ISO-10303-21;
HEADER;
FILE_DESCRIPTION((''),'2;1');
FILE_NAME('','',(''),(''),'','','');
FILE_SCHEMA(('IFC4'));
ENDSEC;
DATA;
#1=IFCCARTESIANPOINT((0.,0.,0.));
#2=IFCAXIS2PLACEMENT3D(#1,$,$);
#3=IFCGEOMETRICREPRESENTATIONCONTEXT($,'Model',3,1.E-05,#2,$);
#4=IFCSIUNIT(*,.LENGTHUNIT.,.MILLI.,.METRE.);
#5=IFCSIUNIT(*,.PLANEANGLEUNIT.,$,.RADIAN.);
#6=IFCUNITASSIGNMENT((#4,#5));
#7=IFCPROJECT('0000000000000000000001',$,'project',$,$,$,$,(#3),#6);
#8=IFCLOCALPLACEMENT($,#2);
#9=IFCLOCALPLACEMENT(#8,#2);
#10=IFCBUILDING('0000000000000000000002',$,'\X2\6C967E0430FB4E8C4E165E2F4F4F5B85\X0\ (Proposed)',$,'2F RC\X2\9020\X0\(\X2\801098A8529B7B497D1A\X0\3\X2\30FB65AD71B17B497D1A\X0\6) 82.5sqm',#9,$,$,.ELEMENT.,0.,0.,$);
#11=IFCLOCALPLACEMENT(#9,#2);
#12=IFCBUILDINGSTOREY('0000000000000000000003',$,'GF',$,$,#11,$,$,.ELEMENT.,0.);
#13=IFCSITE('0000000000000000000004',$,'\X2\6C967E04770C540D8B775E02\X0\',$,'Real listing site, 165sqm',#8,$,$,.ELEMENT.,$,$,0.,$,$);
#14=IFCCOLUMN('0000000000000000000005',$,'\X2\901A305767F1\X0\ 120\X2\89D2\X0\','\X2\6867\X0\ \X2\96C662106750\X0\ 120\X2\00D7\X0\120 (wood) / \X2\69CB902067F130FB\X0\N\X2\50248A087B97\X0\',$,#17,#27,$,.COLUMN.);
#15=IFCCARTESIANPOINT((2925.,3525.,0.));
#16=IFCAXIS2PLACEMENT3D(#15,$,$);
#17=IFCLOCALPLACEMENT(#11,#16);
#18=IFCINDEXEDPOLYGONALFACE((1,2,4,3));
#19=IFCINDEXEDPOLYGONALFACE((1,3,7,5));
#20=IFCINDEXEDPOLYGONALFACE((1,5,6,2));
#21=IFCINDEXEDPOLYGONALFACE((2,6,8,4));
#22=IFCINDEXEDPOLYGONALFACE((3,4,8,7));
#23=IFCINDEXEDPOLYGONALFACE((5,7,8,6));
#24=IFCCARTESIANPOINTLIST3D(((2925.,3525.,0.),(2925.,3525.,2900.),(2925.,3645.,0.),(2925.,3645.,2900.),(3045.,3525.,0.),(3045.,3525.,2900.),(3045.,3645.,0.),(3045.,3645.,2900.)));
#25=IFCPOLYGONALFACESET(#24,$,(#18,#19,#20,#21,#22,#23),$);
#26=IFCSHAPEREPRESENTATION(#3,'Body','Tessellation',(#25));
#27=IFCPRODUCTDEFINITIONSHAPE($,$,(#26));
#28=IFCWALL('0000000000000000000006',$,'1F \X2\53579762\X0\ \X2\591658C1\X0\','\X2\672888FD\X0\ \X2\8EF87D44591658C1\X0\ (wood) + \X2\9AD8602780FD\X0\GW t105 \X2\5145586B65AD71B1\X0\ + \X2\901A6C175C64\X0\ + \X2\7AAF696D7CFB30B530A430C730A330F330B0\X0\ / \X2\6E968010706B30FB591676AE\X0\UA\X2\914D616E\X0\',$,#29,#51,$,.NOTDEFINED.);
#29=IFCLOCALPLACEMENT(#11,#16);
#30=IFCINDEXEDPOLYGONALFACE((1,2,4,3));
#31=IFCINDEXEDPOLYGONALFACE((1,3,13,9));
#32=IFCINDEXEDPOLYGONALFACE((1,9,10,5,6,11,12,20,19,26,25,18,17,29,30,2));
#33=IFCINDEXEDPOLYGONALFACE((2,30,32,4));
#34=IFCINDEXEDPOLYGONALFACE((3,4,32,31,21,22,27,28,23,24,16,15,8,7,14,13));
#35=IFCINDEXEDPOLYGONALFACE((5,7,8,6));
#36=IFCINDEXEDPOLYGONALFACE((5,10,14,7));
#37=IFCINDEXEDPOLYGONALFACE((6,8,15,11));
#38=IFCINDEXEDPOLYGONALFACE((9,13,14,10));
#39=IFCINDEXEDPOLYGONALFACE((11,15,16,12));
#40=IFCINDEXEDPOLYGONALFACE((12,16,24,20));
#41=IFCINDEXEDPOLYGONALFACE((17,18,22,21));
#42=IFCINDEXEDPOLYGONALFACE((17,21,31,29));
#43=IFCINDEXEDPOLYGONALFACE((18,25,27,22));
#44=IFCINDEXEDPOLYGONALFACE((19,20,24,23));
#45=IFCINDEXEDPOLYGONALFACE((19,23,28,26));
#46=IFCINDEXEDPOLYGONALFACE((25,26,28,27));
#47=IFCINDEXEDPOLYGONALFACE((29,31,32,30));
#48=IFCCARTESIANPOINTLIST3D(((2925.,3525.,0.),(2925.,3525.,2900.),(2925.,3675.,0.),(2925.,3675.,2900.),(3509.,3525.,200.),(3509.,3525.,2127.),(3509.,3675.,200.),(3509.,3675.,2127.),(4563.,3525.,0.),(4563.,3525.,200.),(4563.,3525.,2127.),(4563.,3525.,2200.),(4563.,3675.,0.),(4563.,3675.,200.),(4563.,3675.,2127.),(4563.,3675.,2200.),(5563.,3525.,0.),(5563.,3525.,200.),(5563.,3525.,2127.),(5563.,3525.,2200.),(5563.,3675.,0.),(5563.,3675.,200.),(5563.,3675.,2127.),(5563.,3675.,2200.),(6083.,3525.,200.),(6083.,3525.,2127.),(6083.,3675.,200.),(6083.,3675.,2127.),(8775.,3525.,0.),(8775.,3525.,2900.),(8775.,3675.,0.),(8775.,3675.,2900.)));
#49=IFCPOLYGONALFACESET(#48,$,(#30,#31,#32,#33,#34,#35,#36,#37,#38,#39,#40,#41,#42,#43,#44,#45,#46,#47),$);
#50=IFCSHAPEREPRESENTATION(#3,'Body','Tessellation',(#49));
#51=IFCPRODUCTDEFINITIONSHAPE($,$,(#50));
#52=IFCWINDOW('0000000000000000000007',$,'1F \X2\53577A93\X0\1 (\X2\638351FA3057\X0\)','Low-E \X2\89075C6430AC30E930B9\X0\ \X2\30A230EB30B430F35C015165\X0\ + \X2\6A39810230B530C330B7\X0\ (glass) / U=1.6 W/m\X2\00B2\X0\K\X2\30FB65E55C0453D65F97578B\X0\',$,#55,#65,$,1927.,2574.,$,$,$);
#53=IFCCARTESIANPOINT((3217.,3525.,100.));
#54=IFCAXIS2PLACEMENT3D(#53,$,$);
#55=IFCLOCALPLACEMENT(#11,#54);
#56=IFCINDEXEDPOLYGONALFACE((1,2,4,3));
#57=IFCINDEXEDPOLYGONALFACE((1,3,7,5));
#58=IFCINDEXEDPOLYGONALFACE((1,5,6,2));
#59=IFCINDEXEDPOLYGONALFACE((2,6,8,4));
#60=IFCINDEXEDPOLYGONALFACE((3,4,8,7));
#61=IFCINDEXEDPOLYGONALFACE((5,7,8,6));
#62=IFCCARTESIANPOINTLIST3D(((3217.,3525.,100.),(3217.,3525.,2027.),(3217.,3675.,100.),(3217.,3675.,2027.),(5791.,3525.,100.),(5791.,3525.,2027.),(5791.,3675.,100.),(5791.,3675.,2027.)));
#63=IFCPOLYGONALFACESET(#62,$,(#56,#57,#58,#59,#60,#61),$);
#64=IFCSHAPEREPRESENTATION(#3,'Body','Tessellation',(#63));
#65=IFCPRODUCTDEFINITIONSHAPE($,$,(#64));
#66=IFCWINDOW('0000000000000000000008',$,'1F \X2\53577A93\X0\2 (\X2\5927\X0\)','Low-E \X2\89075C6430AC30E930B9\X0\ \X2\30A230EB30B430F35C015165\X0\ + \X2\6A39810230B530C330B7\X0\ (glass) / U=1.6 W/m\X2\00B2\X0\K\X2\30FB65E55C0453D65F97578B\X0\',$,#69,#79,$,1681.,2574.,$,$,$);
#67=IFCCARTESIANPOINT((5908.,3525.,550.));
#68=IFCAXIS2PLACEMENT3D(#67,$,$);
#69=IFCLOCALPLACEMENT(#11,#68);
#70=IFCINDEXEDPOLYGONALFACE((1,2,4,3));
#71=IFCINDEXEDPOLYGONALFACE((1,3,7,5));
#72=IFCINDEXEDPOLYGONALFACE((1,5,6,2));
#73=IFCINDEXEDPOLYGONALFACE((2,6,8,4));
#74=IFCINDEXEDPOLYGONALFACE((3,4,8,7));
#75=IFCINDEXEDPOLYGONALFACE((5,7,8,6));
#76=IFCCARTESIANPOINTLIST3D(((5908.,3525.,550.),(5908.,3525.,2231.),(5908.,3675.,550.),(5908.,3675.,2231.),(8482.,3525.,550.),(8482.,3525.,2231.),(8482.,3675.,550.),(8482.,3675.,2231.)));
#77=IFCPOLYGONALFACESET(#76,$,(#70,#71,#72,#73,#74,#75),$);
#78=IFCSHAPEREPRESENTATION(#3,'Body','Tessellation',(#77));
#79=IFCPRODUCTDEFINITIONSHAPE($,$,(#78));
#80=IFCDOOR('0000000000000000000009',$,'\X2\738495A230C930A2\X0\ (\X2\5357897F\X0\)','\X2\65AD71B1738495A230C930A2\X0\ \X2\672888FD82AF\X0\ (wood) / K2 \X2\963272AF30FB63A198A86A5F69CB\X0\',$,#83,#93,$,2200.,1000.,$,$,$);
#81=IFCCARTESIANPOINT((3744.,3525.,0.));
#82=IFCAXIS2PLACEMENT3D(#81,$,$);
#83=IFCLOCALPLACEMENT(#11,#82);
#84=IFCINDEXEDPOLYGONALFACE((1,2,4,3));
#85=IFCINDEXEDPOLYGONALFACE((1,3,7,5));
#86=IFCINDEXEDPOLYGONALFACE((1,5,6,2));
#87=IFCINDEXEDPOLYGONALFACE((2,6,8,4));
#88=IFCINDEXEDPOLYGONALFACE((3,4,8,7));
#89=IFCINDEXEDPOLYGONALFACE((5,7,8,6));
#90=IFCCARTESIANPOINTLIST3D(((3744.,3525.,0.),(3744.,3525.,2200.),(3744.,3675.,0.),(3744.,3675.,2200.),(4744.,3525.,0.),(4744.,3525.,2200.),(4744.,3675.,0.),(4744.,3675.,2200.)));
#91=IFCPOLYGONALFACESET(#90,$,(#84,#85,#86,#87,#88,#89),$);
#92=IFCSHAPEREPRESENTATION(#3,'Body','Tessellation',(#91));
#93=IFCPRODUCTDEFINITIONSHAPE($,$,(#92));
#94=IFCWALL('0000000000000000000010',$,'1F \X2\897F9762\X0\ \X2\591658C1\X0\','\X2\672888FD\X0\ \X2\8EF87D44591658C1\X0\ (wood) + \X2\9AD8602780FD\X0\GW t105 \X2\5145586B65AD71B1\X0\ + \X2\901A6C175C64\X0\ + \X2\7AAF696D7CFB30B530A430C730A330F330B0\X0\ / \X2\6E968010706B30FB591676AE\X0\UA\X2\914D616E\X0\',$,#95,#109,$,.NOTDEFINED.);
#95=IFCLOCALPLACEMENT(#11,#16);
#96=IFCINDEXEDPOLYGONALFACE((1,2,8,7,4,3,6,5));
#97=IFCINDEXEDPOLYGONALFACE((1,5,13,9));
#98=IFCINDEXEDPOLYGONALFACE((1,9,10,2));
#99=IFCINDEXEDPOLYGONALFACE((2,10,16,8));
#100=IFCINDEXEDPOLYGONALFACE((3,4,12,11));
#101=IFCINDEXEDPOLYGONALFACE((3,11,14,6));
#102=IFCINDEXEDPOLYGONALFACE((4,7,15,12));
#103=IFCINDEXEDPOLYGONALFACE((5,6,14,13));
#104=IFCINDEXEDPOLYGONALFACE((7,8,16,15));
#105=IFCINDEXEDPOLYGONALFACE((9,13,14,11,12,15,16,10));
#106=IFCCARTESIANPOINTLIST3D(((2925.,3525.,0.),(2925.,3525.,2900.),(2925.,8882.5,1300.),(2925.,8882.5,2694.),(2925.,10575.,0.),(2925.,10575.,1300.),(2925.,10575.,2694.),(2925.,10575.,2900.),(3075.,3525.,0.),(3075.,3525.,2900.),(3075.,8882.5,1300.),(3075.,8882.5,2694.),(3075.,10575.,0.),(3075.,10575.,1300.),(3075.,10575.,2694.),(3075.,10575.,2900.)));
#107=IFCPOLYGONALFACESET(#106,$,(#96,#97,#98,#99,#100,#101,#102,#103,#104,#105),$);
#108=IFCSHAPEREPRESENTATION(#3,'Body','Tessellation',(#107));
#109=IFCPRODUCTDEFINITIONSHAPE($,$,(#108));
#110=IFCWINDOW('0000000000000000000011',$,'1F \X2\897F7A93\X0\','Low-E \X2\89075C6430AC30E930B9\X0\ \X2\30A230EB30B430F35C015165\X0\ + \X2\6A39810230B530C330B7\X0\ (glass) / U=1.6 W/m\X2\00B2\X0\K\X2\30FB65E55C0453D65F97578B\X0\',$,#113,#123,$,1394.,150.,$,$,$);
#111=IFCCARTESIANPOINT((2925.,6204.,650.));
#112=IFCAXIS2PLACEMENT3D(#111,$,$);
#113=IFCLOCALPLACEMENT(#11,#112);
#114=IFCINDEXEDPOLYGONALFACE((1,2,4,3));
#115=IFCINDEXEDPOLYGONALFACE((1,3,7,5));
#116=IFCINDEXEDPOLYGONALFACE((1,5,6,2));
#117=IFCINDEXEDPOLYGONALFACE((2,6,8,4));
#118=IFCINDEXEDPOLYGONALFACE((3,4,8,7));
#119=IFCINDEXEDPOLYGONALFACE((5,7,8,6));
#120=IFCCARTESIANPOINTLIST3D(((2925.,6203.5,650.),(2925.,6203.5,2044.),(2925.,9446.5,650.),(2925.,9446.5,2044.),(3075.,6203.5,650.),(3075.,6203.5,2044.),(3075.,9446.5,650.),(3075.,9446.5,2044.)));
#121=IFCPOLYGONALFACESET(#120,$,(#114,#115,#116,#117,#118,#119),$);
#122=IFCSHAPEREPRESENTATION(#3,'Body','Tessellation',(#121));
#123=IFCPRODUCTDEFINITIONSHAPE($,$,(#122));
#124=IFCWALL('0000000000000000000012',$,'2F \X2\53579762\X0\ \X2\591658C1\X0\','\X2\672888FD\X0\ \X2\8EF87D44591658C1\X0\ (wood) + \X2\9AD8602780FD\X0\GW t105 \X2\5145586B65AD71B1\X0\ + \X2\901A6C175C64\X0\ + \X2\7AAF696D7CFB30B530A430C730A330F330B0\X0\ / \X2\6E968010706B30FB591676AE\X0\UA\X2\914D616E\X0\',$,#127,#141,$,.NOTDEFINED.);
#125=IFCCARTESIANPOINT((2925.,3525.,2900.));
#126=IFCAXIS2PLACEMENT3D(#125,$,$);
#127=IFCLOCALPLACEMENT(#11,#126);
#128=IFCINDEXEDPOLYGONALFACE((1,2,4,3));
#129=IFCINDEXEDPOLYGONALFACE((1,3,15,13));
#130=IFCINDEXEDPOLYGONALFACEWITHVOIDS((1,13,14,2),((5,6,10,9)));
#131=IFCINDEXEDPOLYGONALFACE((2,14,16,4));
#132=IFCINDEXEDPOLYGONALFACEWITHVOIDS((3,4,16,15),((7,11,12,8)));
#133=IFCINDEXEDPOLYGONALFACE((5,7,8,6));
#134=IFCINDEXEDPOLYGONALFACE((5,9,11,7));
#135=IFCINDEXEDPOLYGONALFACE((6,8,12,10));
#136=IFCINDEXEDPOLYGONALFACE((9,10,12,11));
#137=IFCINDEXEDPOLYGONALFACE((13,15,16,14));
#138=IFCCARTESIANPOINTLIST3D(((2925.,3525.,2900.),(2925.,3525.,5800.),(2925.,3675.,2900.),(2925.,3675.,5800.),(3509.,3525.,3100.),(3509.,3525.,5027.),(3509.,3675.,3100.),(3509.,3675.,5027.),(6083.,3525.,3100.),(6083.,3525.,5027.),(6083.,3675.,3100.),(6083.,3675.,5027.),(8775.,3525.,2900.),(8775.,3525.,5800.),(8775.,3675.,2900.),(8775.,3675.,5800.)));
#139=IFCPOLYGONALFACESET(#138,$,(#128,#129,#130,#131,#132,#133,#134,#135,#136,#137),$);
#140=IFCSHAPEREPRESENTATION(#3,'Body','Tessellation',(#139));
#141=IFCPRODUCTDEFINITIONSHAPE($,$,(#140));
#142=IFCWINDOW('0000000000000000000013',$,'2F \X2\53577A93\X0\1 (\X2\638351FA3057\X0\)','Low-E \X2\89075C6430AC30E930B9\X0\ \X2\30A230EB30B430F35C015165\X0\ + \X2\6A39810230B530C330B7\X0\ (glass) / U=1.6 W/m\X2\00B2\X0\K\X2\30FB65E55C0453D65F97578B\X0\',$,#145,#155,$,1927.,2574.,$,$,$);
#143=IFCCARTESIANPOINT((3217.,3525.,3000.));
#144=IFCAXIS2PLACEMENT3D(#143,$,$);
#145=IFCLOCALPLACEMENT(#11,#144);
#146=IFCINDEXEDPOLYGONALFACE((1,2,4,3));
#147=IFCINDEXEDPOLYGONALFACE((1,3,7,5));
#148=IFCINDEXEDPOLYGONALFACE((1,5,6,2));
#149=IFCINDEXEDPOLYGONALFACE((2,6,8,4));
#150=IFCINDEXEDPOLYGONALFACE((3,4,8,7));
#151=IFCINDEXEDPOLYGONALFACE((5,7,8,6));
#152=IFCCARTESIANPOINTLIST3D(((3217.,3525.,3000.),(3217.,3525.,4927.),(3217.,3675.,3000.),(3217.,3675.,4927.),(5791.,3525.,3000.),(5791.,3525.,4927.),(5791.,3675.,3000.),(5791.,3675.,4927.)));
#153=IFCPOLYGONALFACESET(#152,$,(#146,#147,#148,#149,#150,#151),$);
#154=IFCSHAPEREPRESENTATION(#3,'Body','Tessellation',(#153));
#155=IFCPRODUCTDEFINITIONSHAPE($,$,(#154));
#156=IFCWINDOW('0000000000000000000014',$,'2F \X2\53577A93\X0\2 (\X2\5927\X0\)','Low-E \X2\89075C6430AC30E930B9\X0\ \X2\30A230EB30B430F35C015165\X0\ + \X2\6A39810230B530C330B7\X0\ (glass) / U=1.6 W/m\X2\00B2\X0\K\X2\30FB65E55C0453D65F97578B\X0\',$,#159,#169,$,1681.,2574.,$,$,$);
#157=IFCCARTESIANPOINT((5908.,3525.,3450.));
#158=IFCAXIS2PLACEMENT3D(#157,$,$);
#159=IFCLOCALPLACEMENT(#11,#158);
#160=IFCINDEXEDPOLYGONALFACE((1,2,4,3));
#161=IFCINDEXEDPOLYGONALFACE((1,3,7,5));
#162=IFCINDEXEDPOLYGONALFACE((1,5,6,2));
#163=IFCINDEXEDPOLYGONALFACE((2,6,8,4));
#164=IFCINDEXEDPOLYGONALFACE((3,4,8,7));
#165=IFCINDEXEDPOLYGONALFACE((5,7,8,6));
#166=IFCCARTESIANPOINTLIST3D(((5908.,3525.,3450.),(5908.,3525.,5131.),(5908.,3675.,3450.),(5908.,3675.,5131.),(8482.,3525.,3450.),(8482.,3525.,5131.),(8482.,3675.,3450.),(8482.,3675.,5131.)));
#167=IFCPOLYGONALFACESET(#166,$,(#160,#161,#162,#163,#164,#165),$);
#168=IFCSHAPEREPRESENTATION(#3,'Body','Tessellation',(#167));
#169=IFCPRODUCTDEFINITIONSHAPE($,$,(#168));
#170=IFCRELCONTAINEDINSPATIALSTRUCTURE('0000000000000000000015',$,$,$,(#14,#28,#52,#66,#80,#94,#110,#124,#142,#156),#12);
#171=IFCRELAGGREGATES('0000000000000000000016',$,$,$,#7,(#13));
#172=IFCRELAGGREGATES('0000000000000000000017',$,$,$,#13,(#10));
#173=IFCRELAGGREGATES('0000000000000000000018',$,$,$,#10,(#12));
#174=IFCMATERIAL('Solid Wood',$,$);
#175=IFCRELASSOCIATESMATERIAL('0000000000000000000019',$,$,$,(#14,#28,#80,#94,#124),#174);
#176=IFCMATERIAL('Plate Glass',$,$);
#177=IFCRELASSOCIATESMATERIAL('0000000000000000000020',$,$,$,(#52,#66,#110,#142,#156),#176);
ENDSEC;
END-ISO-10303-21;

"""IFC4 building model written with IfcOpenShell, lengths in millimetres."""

from ifc_helpers import new_model, si_unit, frame, frame_2d, origin, place, context, project, spatial, rectangle, extrude, material, element, fill, save


model = new_model("IFC4")

# Units and contexts
model_context = context("Model", 3, precision=1e-05, world=origin())
ifc_project = project(units=[si_unit("LENGTHUNIT", "METRE", prefix="MILLI"), si_unit("PLANEANGLEUNIT", "RADIAN")], contexts=[model_context])

# Site, building, storey
site_placement = place(None, origin())
site = spatial("IfcSite", under=ifc_project, at=site_placement, Name="沖縄県名護市", ObjectType="Real listing site, 165sqm", CompositionType="ELEMENT", RefElevation=0.0)
building_placement = place(site_placement, origin())
building = spatial("IfcBuilding", under=site, at=building_placement, Name="沖縄・二世帯住宅 (Proposed)", ObjectType="2F RC造(耐風力等級3・断熱等級6) 82.5sqm", CompositionType="ELEMENT", ElevationOfRefHeight=0.0, ElevationOfTerrain=0.0)
storey_placement = place(building_placement, origin())
storey = spatial("IfcBuildingStorey", under=building, at=storey_placement, Name="GF", CompositionType="ELEMENT", Elevation=0.0)

# Column
ifc_material_1 = material(Name="Solid Wood")
column_placement = place(storey_placement, frame((2925.0, 3525.0, 0.0)))
element("IfcColumn", 1, at=column_placement, inside=storey, material=ifc_material_1, Name="通し柱 120角", Description="桧 集成材 120×120 (wood) / 構造柱・N値計算", PredefinedType="COLUMN", context=model_context, shape_type="SweptSolid", body=[
    extrude(rectangle(XDim=120.0, YDim=120.0, at=frame_2d((60.0, 60.0))), frame((2925.0, 3525.0, 0.0)), (0.0, 0.0, 1.0), 2900.0),
])

# Wall, openings, windows, door
wall_1_placement = place(storey_placement, frame((2925.0, 3525.0, 0.0)))
wall_1 = element("IfcWall", 2, at=wall_1_placement, inside=storey, material=ifc_material_1, Name="1F 南面 外壁", Description="木製 軸組外壁 (wood) + 高性能GW t105 充填断熱 + 通気層 + 窯業系サイディング / 準耐火・外皮UA配慮", PredefinedType="NOTDEFINED", context=model_context, shape_type="SweptSolid", body=[
    extrude(rectangle(XDim=5850.0, YDim=150.0, at=frame_2d((2925.0, 75.0))), frame((2925.0, 3525.0, 0.0)), (0.0, 0.0, 1.0), 2900.0),
])
opening_1_placement = place(storey_placement, frame((3217.0, 3525.0, 100.0)))
opening_1 = element("IfcOpeningElement", 3, at=opening_1_placement, cuts=wall_1, PredefinedType="NOTDEFINED", context=model_context, shape_type="SweptSolid", body=[
    extrude(rectangle(XDim=2574.0, YDim=150.0, at=frame_2d((1287.0, 75.0))), frame((3217.0, 3525.0, 100.0)), (0.0, 0.0, 1.0), 1927.0),
])
opening_2_placement = place(storey_placement, frame((5908.0, 3525.0, 550.0)))
opening_2 = element("IfcOpeningElement", 4, at=opening_2_placement, cuts=wall_1, PredefinedType="NOTDEFINED", context=model_context, shape_type="SweptSolid", body=[
    extrude(rectangle(XDim=2574.0, YDim=150.0, at=frame_2d((1287.0, 75.0))), frame((5908.0, 3525.0, 550.0)), (0.0, 0.0, 1.0), 1681.0),
])
opening_3_placement = place(storey_placement, frame((3744.0, 3525.0, 0.0)))
opening_3 = element("IfcOpeningElement", 5, at=opening_3_placement, cuts=wall_1, PredefinedType="NOTDEFINED", context=model_context, shape_type="SweptSolid", body=[
    extrude(rectangle(XDim=1000.0, YDim=150.0, at=frame_2d((500.0, 75.0))), frame((3744.0, 3525.0, 0.0)), (0.0, 0.0, 1.0), 2200.0),
])
ifc_material_2 = material(Name="Plate Glass")
window_1_placement = place(storey_placement, frame((3217.0, 3525.0, 100.0)))
window_1 = element("IfcWindow", 6, at=window_1_placement, inside=storey, material=ifc_material_2, Name="1F 南窓1 (掃出し)", Description="Low-E 複層ガラス アルゴン封入 + 樹脂サッシ (glass) / U=1.6 W/m²K・日射取得型", OverallHeight=1927.0, OverallWidth=2574.0, context=model_context, shape_type="SweptSolid", body=[
    extrude(rectangle(XDim=2574.0, YDim=150.0, at=frame_2d((1287.0, 75.0))), frame((3217.0, 3525.0, 100.0)), (0.0, 0.0, 1.0), 1927.0),
])
fill(opening_1, window_1)
window_2_placement = place(storey_placement, frame((5908.0, 3525.0, 550.0)))
window_2 = element("IfcWindow", 7, at=window_2_placement, inside=storey, material=ifc_material_2, Name="1F 南窓2 (大)", Description="Low-E 複層ガラス アルゴン封入 + 樹脂サッシ (glass) / U=1.6 W/m²K・日射取得型", OverallHeight=1681.0, OverallWidth=2574.0, context=model_context, shape_type="SweptSolid", body=[
    extrude(rectangle(XDim=2574.0, YDim=150.0, at=frame_2d((1287.0, 75.0))), frame((5908.0, 3525.0, 550.0)), (0.0, 0.0, 1.0), 1681.0),
])
fill(opening_2, window_2)
door_placement = place(storey_placement, frame((3744.0, 3525.0, 0.0)))
door = element("IfcDoor", 8, at=door_placement, inside=storey, material=ifc_material_1, Name="玄関ドア (南西)", Description="断熱玄関ドア 木製芯 (wood) / K2 防犯・採風機構", OverallHeight=2200.0, OverallWidth=1000.0, context=model_context, shape_type="SweptSolid", body=[
    extrude(rectangle(XDim=1000.0, YDim=150.0, at=frame_2d((500.0, 75.0))), frame((3744.0, 3525.0, 0.0)), (0.0, 0.0, 1.0), 2200.0),
])
fill(opening_3, door)

# Wall, opening, window
wall_2_placement = place(storey_placement, frame((2925.0, 3525.0, 0.0)))
wall_2 = element("IfcWall", 9, at=wall_2_placement, inside=storey, material=ifc_material_1, Name="1F 西面 外壁", Description="木製 軸組外壁 (wood) + 高性能GW t105 充填断熱 + 通気層 + 窯業系サイディング / 準耐火・外皮UA配慮", PredefinedType="NOTDEFINED", context=model_context, shape_type="SweptSolid", body=[
    extrude(rectangle(XDim=150.0, YDim=7050.0, at=frame_2d((75.0, 3525.0))), frame((2925.0, 3525.0, 0.0)), (0.0, 0.0, 1.0), 2900.0),
])
opening_4_placement = place(storey_placement, frame((2925.0, 6204.0, 650.0)))
opening_4 = element("IfcOpeningElement", 10, at=opening_4_placement, cuts=wall_2, PredefinedType="NOTDEFINED", context=model_context, shape_type="SweptSolid", body=[
    extrude(rectangle(XDim=150.0, YDim=3243.0, at=frame_2d((75.0, 1621.0))), frame((2925.0, 6204.0, 650.0)), (0.0, 0.0, 1.0), 1394.0),
])
window_3_placement = place(storey_placement, frame((2925.0, 6204.0, 650.0)))
window_3 = element("IfcWindow", 11, at=window_3_placement, inside=storey, material=ifc_material_2, Name="1F 西窓", Description="Low-E 複層ガラス アルゴン封入 + 樹脂サッシ (glass) / U=1.6 W/m²K・日射取得型", OverallHeight=1394.0, OverallWidth=150.0, context=model_context, shape_type="SweptSolid", body=[
    extrude(rectangle(XDim=150.0, YDim=3243.0, at=frame_2d((75.0, 1621.0))), frame((2925.0, 6204.0, 650.0)), (0.0, 0.0, 1.0), 1394.0),
])
fill(opening_4, window_3)

# Wall, openings, windows
wall_3_placement = place(storey_placement, frame((2925.0, 3525.0, 2900.0)))
wall_3 = element("IfcWall", 12, at=wall_3_placement, inside=storey, material=ifc_material_1, Name="2F 南面 外壁", Description="木製 軸組外壁 (wood) + 高性能GW t105 充填断熱 + 通気層 + 窯業系サイディング / 準耐火・外皮UA配慮", PredefinedType="NOTDEFINED", context=model_context, shape_type="SweptSolid", body=[
    extrude(rectangle(XDim=5850.0, YDim=150.0, at=frame_2d((2925.0, 75.0))), frame((2925.0, 3525.0, 2900.0)), (0.0, 0.0, 1.0), 2900.0),
])
opening_5_placement = place(storey_placement, frame((3217.0, 3525.0, 3000.0)))
opening_5 = element("IfcOpeningElement", 13, at=opening_5_placement, cuts=wall_3, PredefinedType="NOTDEFINED", context=model_context, shape_type="SweptSolid", body=[
    extrude(rectangle(XDim=2574.0, YDim=150.0, at=frame_2d((1287.0, 75.0))), frame((3217.0, 3525.0, 3000.0)), (0.0, 0.0, 1.0), 1927.0),
])
opening_6_placement = place(storey_placement, frame((5908.0, 3525.0, 3450.0)))
opening_6 = element("IfcOpeningElement", 14, at=opening_6_placement, cuts=wall_3, PredefinedType="NOTDEFINED", context=model_context, shape_type="SweptSolid", body=[
    extrude(rectangle(XDim=2574.0, YDim=150.0, at=frame_2d((1287.0, 75.0))), frame((5908.0, 3525.0, 3450.0)), (0.0, 0.0, 1.0), 1681.0),
])
window_4_placement = place(storey_placement, frame((3217.0, 3525.0, 3000.0)))
window_4 = element("IfcWindow", 15, at=window_4_placement, inside=storey, material=ifc_material_2, Name="2F 南窓1 (掃出し)", Description="Low-E 複層ガラス アルゴン封入 + 樹脂サッシ (glass) / U=1.6 W/m²K・日射取得型", OverallHeight=1927.0, OverallWidth=2574.0, context=model_context, shape_type="SweptSolid", body=[
    extrude(rectangle(XDim=2574.0, YDim=150.0, at=frame_2d((1287.0, 75.0))), frame((3217.0, 3525.0, 3000.0)), (0.0, 0.0, 1.0), 1927.0),
])
fill(opening_5, window_4)
window_5_placement = place(storey_placement, frame((5908.0, 3525.0, 3450.0)))
window_5 = element("IfcWindow", 16, at=window_5_placement, inside=storey, material=ifc_material_2, Name="2F 南窓2 (大)", Description="Low-E 複層ガラス アルゴン封入 + 樹脂サッシ (glass) / U=1.6 W/m²K・日射取得型", OverallHeight=1681.0, OverallWidth=2574.0, context=model_context, shape_type="SweptSolid", body=[
    extrude(rectangle(XDim=2574.0, YDim=150.0, at=frame_2d((1287.0, 75.0))), frame((5908.0, 3525.0, 3450.0)), (0.0, 0.0, 1.0), 1681.0),
])
fill(opening_6, window_5)

save(model, "model.ifc")
